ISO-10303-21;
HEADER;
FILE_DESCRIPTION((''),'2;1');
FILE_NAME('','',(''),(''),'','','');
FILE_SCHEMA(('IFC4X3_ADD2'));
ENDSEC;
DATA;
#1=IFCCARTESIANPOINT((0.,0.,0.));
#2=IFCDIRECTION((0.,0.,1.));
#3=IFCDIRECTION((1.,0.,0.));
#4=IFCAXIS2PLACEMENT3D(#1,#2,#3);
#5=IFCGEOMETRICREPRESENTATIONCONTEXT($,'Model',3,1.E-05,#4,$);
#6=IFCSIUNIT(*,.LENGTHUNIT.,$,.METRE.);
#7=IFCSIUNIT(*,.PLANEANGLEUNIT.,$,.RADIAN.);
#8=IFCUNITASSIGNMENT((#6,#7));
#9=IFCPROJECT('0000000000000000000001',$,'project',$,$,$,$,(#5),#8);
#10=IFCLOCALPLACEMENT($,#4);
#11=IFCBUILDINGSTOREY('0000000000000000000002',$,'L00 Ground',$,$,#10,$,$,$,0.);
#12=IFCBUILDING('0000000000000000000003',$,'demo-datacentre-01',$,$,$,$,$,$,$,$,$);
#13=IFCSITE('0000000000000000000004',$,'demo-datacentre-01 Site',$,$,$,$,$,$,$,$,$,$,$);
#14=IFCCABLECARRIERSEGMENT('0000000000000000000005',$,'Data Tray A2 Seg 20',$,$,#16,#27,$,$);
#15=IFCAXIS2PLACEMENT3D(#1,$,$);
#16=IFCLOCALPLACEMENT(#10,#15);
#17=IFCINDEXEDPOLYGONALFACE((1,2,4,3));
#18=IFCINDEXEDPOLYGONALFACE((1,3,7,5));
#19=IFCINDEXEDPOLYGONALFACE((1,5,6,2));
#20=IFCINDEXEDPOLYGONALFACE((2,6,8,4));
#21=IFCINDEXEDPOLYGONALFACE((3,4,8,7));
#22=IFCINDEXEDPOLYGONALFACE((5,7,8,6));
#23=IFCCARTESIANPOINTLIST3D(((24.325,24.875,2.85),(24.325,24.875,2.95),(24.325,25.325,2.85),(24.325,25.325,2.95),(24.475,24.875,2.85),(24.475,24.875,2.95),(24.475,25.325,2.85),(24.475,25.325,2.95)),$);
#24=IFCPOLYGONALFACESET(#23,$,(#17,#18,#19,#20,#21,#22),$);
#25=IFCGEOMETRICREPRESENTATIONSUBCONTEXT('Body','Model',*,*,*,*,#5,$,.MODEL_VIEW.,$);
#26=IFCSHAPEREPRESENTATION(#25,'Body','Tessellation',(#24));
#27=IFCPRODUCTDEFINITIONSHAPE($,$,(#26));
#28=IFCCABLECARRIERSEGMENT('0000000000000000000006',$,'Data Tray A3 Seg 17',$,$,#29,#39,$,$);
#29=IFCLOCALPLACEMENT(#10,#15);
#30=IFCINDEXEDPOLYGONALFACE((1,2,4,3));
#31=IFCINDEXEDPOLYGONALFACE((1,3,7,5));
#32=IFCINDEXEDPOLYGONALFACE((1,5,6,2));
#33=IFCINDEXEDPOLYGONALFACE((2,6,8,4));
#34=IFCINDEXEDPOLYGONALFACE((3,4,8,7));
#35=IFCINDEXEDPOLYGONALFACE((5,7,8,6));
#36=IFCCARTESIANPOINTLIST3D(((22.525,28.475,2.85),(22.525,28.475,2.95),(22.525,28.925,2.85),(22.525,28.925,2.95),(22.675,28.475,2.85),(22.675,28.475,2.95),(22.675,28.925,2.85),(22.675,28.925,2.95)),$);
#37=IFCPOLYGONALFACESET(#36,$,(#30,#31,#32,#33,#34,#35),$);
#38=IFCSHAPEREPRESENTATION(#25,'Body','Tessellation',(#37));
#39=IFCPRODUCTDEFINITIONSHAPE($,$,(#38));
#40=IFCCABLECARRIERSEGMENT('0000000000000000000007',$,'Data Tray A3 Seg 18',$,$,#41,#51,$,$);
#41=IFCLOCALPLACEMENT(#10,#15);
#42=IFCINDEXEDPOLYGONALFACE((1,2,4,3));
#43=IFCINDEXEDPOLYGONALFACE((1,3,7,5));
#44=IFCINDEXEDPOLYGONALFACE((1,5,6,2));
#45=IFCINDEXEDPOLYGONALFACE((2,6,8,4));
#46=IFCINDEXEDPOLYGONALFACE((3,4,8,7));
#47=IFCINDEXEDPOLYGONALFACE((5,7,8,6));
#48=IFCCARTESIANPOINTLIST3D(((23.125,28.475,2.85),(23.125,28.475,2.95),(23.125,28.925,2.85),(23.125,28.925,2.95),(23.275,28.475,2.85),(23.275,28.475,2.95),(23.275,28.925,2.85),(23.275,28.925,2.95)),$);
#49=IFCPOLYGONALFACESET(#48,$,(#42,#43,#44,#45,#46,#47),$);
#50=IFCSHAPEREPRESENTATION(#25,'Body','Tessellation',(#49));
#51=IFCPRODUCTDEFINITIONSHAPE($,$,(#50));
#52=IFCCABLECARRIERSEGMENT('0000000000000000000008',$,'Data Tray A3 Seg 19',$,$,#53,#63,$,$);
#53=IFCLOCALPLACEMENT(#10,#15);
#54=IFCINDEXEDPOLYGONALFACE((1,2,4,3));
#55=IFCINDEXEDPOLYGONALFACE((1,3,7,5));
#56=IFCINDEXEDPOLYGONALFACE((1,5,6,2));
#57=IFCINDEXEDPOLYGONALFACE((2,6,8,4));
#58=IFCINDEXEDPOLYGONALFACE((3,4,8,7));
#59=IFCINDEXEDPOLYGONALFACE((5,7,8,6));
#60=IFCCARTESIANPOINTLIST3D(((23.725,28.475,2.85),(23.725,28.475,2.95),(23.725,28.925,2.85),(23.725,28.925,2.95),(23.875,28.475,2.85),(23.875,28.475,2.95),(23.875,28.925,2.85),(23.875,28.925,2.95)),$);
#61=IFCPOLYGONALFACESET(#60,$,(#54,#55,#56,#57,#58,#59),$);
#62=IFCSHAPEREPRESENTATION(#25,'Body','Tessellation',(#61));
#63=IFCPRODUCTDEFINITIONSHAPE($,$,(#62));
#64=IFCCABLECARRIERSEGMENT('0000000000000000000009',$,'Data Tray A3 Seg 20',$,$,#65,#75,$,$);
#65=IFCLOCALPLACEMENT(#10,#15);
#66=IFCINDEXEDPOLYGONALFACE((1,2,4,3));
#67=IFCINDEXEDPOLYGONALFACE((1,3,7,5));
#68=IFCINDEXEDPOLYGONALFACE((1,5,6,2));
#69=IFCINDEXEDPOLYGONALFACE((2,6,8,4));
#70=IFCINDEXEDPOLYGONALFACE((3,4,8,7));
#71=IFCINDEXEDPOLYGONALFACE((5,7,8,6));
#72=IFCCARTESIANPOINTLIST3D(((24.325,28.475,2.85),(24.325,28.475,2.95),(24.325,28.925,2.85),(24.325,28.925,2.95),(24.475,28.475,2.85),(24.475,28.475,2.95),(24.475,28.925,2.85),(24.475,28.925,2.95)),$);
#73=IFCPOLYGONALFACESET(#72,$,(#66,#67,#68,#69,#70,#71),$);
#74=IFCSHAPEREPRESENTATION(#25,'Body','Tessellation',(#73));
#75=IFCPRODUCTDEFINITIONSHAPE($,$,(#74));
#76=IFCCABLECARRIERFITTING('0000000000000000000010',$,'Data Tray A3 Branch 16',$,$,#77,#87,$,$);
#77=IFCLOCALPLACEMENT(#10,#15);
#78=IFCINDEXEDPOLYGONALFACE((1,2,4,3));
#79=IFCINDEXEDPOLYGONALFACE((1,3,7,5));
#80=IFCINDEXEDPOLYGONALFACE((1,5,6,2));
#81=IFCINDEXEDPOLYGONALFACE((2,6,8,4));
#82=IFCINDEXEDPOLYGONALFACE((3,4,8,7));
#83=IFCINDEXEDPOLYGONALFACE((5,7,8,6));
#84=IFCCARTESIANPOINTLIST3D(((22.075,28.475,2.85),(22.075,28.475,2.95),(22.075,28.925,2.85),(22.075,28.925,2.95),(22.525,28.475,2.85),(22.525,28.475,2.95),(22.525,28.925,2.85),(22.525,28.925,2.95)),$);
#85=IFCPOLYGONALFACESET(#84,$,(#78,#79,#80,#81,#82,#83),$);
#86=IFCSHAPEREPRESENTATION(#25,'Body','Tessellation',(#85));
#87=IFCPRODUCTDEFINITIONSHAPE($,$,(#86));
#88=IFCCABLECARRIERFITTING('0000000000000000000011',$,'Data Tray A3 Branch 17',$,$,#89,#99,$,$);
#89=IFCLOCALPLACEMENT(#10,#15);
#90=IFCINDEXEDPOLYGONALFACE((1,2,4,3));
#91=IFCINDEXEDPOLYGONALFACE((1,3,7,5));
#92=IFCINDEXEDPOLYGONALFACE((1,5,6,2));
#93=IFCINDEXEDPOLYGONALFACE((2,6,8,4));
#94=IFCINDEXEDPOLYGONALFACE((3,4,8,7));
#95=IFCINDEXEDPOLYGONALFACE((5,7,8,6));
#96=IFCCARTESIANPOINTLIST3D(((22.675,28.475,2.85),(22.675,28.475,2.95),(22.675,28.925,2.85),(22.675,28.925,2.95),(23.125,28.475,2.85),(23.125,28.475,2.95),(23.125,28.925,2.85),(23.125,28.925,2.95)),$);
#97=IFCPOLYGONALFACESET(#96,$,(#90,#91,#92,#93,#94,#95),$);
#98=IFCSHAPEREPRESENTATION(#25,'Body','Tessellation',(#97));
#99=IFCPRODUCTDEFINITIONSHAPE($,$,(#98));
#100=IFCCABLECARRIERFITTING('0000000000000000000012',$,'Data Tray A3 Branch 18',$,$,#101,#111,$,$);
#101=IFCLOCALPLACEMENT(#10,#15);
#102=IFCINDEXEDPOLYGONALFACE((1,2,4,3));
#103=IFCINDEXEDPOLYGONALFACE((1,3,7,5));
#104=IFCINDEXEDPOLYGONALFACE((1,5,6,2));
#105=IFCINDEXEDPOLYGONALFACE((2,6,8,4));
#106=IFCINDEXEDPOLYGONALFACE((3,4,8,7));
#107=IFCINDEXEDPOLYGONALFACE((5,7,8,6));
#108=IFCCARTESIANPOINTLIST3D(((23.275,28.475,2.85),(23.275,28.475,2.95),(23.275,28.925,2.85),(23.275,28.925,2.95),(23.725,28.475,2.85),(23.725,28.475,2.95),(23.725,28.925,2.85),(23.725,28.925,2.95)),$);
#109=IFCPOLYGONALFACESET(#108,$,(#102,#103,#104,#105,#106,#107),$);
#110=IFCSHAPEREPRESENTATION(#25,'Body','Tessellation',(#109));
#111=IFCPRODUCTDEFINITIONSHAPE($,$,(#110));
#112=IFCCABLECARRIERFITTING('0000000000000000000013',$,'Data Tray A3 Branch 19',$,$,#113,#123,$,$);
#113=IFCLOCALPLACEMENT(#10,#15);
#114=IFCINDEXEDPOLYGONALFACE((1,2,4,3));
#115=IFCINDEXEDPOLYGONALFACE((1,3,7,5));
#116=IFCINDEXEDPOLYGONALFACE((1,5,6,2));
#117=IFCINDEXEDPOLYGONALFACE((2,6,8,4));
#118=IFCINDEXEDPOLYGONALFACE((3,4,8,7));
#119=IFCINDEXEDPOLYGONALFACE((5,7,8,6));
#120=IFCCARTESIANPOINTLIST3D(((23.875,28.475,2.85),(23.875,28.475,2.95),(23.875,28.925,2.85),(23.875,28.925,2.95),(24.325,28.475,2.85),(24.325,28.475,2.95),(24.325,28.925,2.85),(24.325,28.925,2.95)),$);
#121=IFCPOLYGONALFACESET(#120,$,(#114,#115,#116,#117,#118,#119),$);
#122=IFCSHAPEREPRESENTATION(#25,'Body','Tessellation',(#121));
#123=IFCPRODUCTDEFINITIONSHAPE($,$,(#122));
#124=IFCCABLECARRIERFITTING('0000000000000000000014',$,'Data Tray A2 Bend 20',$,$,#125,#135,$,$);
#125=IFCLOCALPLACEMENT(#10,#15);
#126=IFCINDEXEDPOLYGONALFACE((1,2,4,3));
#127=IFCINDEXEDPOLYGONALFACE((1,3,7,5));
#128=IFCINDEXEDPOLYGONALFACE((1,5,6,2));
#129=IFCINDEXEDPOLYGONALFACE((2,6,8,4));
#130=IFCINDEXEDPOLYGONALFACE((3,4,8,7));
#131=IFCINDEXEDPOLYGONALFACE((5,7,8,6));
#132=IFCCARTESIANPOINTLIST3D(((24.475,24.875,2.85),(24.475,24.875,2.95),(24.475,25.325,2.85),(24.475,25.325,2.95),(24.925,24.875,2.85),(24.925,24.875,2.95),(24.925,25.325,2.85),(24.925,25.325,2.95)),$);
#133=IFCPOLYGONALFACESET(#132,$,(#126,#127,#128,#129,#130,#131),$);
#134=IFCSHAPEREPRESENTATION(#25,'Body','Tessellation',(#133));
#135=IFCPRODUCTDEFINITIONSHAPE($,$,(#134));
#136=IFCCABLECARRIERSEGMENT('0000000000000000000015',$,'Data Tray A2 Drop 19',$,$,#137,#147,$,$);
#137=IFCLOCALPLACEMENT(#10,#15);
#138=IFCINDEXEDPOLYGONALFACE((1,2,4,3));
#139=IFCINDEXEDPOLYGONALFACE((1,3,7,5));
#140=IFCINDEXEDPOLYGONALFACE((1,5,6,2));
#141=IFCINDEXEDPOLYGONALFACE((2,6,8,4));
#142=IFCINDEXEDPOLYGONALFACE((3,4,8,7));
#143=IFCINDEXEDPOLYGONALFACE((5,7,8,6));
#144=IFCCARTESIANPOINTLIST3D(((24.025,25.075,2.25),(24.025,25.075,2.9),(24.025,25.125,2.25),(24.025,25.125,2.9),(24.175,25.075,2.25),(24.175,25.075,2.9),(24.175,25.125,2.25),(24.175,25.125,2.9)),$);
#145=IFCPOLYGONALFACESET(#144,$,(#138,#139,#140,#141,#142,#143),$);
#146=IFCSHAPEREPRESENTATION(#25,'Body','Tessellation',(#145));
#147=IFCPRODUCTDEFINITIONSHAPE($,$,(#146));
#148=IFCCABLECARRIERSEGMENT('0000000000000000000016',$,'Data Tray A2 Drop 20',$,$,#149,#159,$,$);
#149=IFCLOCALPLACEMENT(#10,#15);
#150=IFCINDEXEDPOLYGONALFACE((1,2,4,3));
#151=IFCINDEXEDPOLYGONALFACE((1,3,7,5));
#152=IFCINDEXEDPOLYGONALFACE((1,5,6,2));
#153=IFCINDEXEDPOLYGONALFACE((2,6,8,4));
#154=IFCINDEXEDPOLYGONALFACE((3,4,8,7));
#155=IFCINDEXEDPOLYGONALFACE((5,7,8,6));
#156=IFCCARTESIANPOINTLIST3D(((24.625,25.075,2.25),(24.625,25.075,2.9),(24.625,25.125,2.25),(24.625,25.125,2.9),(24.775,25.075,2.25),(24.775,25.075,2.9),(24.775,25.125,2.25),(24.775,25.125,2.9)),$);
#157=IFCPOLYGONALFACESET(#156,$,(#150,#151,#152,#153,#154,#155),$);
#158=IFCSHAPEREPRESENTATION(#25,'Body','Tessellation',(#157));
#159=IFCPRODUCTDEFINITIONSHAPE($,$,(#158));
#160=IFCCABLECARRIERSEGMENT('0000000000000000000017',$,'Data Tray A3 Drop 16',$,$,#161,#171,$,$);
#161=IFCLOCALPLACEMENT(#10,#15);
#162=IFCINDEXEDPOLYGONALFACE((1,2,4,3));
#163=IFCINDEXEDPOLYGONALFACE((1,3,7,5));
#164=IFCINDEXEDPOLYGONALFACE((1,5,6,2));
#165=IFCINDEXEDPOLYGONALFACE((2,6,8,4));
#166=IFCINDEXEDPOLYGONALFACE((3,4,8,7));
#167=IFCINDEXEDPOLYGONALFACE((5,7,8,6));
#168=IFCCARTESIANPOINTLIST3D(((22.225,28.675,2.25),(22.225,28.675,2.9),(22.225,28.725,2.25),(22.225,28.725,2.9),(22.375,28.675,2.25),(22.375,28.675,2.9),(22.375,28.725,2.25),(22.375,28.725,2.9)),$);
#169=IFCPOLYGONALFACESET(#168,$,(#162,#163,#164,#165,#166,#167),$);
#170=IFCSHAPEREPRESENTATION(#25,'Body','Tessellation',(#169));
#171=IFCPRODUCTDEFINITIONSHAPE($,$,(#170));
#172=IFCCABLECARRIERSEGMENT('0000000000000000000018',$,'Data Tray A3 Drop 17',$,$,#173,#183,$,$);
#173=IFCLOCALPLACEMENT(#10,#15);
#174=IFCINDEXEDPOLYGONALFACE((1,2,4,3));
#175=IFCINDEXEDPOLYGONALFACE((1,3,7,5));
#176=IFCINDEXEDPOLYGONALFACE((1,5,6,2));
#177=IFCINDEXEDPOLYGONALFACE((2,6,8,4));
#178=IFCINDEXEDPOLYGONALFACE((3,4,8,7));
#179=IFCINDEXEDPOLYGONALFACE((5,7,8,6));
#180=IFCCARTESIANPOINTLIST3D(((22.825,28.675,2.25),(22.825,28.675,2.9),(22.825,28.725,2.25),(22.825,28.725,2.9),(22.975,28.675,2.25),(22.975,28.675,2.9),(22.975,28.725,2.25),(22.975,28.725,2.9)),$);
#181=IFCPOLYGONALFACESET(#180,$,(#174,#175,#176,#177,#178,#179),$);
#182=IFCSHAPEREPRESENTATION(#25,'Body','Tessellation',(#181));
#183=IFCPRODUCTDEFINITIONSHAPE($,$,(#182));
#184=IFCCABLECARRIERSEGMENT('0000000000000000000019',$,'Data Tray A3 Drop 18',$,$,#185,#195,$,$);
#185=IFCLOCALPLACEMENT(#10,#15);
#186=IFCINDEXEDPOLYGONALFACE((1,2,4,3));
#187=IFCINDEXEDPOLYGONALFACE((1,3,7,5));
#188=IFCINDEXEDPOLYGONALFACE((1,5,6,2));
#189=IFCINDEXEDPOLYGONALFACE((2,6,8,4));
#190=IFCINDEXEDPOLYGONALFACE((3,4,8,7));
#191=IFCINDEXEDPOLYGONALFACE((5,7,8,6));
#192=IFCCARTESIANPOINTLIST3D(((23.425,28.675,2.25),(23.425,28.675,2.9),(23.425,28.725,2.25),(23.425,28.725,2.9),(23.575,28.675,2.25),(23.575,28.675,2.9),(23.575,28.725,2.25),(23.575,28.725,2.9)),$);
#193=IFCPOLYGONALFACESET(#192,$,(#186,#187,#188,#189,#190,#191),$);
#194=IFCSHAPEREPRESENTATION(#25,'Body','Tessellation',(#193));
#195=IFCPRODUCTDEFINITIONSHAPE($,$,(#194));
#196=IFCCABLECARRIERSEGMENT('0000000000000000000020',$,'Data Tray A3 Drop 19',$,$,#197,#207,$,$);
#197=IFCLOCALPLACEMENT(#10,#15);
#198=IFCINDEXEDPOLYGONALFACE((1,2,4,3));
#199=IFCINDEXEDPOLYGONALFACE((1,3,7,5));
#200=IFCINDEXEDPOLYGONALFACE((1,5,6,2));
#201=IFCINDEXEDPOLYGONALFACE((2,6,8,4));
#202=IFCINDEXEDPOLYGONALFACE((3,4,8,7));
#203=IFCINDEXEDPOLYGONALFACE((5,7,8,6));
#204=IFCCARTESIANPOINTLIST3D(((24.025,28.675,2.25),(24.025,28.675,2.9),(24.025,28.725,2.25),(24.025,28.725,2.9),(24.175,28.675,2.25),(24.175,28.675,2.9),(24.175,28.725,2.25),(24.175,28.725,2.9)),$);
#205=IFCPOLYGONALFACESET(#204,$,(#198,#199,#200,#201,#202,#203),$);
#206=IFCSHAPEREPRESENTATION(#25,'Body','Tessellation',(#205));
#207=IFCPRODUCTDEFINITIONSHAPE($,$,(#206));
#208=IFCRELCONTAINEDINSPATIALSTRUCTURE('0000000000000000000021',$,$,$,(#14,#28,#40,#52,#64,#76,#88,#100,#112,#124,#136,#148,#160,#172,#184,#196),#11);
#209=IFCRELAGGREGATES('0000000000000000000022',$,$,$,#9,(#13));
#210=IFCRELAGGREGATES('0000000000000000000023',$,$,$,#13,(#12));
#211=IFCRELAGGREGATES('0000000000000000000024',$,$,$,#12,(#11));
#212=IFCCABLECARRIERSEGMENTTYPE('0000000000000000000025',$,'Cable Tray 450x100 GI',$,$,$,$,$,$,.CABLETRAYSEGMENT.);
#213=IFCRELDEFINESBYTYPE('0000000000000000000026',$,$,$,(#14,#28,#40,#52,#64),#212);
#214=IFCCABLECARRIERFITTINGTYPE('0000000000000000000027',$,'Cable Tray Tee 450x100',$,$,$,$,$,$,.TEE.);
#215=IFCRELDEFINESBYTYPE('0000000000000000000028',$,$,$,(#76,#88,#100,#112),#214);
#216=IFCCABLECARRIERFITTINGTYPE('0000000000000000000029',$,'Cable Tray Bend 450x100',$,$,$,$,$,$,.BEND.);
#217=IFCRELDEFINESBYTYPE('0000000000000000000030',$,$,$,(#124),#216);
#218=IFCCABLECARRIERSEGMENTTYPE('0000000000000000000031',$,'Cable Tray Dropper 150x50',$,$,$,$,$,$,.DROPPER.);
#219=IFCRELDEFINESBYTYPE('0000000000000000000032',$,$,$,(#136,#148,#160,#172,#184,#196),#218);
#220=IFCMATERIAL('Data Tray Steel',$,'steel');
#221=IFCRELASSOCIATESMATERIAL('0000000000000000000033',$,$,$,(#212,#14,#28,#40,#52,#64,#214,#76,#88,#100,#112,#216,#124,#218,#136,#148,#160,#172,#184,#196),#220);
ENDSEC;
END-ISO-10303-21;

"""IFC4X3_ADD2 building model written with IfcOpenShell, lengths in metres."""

from ifc_helpers import new_model, si_unit, frame, origin_with_axes, place, context, subcontext, project, spatial, rectangle, extrude, material, type_object, element, save


model = new_model("IFC4X3_ADD2")

# Units and contexts
model_context = context("Model", 3, precision=1e-05, world=origin_with_axes())
body_context = subcontext(model_context, "Body", "Model", "MODEL_VIEW")
ifc_project = project(units=[si_unit("LENGTHUNIT", "METRE"), si_unit("PLANEANGLEUNIT", "RADIAN")], contexts=[model_context])

# Site, building, storey
site = spatial("IfcSite", under=ifc_project, Name="demo-datacentre-01 Site")
building = spatial("IfcBuilding", under=site, Name="demo-datacentre-01")
storey_placement = place(None, origin_with_axes())
storey = spatial("IfcBuildingStorey", under=building, at=storey_placement, Name="L00 Ground", Elevation=0.0)

# Cable carrier segments
ifc_material_1 = material(Name="Data Tray Steel", Category="steel")
cable_carrier_segment_type_1 = type_object("IfcCableCarrierSegmentType", Name="Cable Tray 450x100 GI", PredefinedType="CABLETRAYSEGMENT", material=ifc_material_1)
cable_carrier_segment_1_placement = place(storey_placement, frame((24.325, 25.1, 2.9), z_axis=(1.0, 0.0, 0.0), x_axis=(0.0, 1.0, 0.0)))
element("IfcCableCarrierSegment", 1, at=cable_carrier_segment_1_placement, inside=storey, type_object=cable_carrier_segment_type_1, material=ifc_material_1, Name="Data Tray A2 Seg 20", context=body_context, shape_type="SweptSolid", body=[
    extrude(rectangle(XDim=0.45, YDim=0.1), origin_with_axes(), (0.0, 0.0, 1.0), 0.15),
])
cable_carrier_segment_2_placement = place(storey_placement, frame((22.525, 28.7, 2.9), z_axis=(1.0, 0.0, 0.0), x_axis=(0.0, 1.0, 0.0)))
element("IfcCableCarrierSegment", 2, at=cable_carrier_segment_2_placement, inside=storey, type_object=cable_carrier_segment_type_1, material=ifc_material_1, Name="Data Tray A3 Seg 17", context=body_context, shape_type="SweptSolid", body=[
    extrude(rectangle(XDim=0.45, YDim=0.1), origin_with_axes(), (0.0, 0.0, 1.0), 0.15),
])
for number, where, z_axis, x_axis, name in (
    (3, (23.125, 28.7, 2.9), (1.0, 0.0, 0.0), (0.0, 1.0, 0.0), "Data Tray A3 Seg 18"),
    (4, (23.725, 28.7, 2.9), (1.0, 0.0, 0.0), (0.0, 1.0, 0.0), "Data Tray A3 Seg 19"),
    (5, (24.325, 28.7, 2.9), (1.0, 0.0, 0.0), (0.0, 1.0, 0.0), "Data Tray A3 Seg 20"),
):
    element("IfcCableCarrierSegment", number, at=place(storey_placement, frame(where, z_axis=z_axis, x_axis=x_axis)), inside=storey, type_object=cable_carrier_segment_type_1, material=ifc_material_1, Name=name, context=body_context, shape_type="SweptSolid", body=[
        extrude(rectangle(XDim=0.45, YDim=0.1), origin_with_axes(), (0.0, 0.0, 1.0), 0.15),
    ])

# Cable carrier fittings
cable_carrier_fitting_type_1 = type_object("IfcCableCarrierFittingType", Name="Cable Tray Tee 450x100", PredefinedType="TEE", material=ifc_material_1)
for number, where, z_axis, x_axis, name in (
    (6, (22.3, 28.7, 2.85), (0.0, 0.0, 1.0), (1.0, 0.0, 0.0), "Data Tray A3 Branch 16"),
    (7, (22.9, 28.7, 2.85), (0.0, 0.0, 1.0), (1.0, 0.0, 0.0), "Data Tray A3 Branch 17"),
    (8, (23.5, 28.7, 2.85), (0.0, 0.0, 1.0), (1.0, 0.0, 0.0), "Data Tray A3 Branch 18"),
    (9, (24.1, 28.7, 2.85), (0.0, 0.0, 1.0), (1.0, 0.0, 0.0), "Data Tray A3 Branch 19"),
):
    element("IfcCableCarrierFitting", number, at=place(storey_placement, frame(where, z_axis=z_axis, x_axis=x_axis)), inside=storey, type_object=cable_carrier_fitting_type_1, material=ifc_material_1, Name=name, context=body_context, shape_type="SweptSolid", body=[
        extrude(rectangle(XDim=0.45, YDim=0.45), origin_with_axes(), (0.0, 0.0, 1.0), 0.1),
    ])
cable_carrier_fitting_type_2 = type_object("IfcCableCarrierFittingType", Name="Cable Tray Bend 450x100", PredefinedType="BEND", material=ifc_material_1)
cable_carrier_fitting_placement = place(storey_placement, frame((24.7, 25.1, 2.85), z_axis=(0.0, 0.0, 1.0), x_axis=(1.0, 0.0, 0.0)))
element("IfcCableCarrierFitting", 10, at=cable_carrier_fitting_placement, inside=storey, type_object=cable_carrier_fitting_type_2, material=ifc_material_1, Name="Data Tray A2 Bend 20", context=body_context, shape_type="SweptSolid", body=[
    extrude(rectangle(XDim=0.45, YDim=0.45), origin_with_axes(), (0.0, 0.0, 1.0), 0.1),
])

# Cable carrier segments
cable_carrier_segment_type_2 = type_object("IfcCableCarrierSegmentType", Name="Cable Tray Dropper 150x50", PredefinedType="DROPPER", material=ifc_material_1)
for number, where, z_axis, x_axis, name in (
    (11, (24.1, 25.1, 2.9), (0.0, 0.0, -1.0), (1.0, 0.0, 0.0), "Data Tray A2 Drop 19"),
    (12, (24.7, 25.1, 2.9), (0.0, 0.0, -1.0), (1.0, 0.0, 0.0), "Data Tray A2 Drop 20"),
    (13, (22.3, 28.7, 2.9), (0.0, 0.0, -1.0), (1.0, 0.0, 0.0), "Data Tray A3 Drop 16"),
    (14, (22.9, 28.7, 2.9), (0.0, 0.0, -1.0), (1.0, 0.0, 0.0), "Data Tray A3 Drop 17"),
    (15, (23.5, 28.7, 2.9), (0.0, 0.0, -1.0), (1.0, 0.0, 0.0), "Data Tray A3 Drop 18"),
    (16, (24.1, 28.7, 2.9), (0.0, 0.0, -1.0), (1.0, 0.0, 0.0), "Data Tray A3 Drop 19"),
):
    element("IfcCableCarrierSegment", number, at=place(storey_placement, frame(where, z_axis=z_axis, x_axis=x_axis)), inside=storey, type_object=cable_carrier_segment_type_2, material=ifc_material_1, Name=name, context=body_context, shape_type="SweptSolid", body=[
        extrude(rectangle(XDim=0.15, YDim=0.05), origin_with_axes(), (0.0, 0.0, 1.0), 0.65),
    ])

save(model, "model.ifc")
